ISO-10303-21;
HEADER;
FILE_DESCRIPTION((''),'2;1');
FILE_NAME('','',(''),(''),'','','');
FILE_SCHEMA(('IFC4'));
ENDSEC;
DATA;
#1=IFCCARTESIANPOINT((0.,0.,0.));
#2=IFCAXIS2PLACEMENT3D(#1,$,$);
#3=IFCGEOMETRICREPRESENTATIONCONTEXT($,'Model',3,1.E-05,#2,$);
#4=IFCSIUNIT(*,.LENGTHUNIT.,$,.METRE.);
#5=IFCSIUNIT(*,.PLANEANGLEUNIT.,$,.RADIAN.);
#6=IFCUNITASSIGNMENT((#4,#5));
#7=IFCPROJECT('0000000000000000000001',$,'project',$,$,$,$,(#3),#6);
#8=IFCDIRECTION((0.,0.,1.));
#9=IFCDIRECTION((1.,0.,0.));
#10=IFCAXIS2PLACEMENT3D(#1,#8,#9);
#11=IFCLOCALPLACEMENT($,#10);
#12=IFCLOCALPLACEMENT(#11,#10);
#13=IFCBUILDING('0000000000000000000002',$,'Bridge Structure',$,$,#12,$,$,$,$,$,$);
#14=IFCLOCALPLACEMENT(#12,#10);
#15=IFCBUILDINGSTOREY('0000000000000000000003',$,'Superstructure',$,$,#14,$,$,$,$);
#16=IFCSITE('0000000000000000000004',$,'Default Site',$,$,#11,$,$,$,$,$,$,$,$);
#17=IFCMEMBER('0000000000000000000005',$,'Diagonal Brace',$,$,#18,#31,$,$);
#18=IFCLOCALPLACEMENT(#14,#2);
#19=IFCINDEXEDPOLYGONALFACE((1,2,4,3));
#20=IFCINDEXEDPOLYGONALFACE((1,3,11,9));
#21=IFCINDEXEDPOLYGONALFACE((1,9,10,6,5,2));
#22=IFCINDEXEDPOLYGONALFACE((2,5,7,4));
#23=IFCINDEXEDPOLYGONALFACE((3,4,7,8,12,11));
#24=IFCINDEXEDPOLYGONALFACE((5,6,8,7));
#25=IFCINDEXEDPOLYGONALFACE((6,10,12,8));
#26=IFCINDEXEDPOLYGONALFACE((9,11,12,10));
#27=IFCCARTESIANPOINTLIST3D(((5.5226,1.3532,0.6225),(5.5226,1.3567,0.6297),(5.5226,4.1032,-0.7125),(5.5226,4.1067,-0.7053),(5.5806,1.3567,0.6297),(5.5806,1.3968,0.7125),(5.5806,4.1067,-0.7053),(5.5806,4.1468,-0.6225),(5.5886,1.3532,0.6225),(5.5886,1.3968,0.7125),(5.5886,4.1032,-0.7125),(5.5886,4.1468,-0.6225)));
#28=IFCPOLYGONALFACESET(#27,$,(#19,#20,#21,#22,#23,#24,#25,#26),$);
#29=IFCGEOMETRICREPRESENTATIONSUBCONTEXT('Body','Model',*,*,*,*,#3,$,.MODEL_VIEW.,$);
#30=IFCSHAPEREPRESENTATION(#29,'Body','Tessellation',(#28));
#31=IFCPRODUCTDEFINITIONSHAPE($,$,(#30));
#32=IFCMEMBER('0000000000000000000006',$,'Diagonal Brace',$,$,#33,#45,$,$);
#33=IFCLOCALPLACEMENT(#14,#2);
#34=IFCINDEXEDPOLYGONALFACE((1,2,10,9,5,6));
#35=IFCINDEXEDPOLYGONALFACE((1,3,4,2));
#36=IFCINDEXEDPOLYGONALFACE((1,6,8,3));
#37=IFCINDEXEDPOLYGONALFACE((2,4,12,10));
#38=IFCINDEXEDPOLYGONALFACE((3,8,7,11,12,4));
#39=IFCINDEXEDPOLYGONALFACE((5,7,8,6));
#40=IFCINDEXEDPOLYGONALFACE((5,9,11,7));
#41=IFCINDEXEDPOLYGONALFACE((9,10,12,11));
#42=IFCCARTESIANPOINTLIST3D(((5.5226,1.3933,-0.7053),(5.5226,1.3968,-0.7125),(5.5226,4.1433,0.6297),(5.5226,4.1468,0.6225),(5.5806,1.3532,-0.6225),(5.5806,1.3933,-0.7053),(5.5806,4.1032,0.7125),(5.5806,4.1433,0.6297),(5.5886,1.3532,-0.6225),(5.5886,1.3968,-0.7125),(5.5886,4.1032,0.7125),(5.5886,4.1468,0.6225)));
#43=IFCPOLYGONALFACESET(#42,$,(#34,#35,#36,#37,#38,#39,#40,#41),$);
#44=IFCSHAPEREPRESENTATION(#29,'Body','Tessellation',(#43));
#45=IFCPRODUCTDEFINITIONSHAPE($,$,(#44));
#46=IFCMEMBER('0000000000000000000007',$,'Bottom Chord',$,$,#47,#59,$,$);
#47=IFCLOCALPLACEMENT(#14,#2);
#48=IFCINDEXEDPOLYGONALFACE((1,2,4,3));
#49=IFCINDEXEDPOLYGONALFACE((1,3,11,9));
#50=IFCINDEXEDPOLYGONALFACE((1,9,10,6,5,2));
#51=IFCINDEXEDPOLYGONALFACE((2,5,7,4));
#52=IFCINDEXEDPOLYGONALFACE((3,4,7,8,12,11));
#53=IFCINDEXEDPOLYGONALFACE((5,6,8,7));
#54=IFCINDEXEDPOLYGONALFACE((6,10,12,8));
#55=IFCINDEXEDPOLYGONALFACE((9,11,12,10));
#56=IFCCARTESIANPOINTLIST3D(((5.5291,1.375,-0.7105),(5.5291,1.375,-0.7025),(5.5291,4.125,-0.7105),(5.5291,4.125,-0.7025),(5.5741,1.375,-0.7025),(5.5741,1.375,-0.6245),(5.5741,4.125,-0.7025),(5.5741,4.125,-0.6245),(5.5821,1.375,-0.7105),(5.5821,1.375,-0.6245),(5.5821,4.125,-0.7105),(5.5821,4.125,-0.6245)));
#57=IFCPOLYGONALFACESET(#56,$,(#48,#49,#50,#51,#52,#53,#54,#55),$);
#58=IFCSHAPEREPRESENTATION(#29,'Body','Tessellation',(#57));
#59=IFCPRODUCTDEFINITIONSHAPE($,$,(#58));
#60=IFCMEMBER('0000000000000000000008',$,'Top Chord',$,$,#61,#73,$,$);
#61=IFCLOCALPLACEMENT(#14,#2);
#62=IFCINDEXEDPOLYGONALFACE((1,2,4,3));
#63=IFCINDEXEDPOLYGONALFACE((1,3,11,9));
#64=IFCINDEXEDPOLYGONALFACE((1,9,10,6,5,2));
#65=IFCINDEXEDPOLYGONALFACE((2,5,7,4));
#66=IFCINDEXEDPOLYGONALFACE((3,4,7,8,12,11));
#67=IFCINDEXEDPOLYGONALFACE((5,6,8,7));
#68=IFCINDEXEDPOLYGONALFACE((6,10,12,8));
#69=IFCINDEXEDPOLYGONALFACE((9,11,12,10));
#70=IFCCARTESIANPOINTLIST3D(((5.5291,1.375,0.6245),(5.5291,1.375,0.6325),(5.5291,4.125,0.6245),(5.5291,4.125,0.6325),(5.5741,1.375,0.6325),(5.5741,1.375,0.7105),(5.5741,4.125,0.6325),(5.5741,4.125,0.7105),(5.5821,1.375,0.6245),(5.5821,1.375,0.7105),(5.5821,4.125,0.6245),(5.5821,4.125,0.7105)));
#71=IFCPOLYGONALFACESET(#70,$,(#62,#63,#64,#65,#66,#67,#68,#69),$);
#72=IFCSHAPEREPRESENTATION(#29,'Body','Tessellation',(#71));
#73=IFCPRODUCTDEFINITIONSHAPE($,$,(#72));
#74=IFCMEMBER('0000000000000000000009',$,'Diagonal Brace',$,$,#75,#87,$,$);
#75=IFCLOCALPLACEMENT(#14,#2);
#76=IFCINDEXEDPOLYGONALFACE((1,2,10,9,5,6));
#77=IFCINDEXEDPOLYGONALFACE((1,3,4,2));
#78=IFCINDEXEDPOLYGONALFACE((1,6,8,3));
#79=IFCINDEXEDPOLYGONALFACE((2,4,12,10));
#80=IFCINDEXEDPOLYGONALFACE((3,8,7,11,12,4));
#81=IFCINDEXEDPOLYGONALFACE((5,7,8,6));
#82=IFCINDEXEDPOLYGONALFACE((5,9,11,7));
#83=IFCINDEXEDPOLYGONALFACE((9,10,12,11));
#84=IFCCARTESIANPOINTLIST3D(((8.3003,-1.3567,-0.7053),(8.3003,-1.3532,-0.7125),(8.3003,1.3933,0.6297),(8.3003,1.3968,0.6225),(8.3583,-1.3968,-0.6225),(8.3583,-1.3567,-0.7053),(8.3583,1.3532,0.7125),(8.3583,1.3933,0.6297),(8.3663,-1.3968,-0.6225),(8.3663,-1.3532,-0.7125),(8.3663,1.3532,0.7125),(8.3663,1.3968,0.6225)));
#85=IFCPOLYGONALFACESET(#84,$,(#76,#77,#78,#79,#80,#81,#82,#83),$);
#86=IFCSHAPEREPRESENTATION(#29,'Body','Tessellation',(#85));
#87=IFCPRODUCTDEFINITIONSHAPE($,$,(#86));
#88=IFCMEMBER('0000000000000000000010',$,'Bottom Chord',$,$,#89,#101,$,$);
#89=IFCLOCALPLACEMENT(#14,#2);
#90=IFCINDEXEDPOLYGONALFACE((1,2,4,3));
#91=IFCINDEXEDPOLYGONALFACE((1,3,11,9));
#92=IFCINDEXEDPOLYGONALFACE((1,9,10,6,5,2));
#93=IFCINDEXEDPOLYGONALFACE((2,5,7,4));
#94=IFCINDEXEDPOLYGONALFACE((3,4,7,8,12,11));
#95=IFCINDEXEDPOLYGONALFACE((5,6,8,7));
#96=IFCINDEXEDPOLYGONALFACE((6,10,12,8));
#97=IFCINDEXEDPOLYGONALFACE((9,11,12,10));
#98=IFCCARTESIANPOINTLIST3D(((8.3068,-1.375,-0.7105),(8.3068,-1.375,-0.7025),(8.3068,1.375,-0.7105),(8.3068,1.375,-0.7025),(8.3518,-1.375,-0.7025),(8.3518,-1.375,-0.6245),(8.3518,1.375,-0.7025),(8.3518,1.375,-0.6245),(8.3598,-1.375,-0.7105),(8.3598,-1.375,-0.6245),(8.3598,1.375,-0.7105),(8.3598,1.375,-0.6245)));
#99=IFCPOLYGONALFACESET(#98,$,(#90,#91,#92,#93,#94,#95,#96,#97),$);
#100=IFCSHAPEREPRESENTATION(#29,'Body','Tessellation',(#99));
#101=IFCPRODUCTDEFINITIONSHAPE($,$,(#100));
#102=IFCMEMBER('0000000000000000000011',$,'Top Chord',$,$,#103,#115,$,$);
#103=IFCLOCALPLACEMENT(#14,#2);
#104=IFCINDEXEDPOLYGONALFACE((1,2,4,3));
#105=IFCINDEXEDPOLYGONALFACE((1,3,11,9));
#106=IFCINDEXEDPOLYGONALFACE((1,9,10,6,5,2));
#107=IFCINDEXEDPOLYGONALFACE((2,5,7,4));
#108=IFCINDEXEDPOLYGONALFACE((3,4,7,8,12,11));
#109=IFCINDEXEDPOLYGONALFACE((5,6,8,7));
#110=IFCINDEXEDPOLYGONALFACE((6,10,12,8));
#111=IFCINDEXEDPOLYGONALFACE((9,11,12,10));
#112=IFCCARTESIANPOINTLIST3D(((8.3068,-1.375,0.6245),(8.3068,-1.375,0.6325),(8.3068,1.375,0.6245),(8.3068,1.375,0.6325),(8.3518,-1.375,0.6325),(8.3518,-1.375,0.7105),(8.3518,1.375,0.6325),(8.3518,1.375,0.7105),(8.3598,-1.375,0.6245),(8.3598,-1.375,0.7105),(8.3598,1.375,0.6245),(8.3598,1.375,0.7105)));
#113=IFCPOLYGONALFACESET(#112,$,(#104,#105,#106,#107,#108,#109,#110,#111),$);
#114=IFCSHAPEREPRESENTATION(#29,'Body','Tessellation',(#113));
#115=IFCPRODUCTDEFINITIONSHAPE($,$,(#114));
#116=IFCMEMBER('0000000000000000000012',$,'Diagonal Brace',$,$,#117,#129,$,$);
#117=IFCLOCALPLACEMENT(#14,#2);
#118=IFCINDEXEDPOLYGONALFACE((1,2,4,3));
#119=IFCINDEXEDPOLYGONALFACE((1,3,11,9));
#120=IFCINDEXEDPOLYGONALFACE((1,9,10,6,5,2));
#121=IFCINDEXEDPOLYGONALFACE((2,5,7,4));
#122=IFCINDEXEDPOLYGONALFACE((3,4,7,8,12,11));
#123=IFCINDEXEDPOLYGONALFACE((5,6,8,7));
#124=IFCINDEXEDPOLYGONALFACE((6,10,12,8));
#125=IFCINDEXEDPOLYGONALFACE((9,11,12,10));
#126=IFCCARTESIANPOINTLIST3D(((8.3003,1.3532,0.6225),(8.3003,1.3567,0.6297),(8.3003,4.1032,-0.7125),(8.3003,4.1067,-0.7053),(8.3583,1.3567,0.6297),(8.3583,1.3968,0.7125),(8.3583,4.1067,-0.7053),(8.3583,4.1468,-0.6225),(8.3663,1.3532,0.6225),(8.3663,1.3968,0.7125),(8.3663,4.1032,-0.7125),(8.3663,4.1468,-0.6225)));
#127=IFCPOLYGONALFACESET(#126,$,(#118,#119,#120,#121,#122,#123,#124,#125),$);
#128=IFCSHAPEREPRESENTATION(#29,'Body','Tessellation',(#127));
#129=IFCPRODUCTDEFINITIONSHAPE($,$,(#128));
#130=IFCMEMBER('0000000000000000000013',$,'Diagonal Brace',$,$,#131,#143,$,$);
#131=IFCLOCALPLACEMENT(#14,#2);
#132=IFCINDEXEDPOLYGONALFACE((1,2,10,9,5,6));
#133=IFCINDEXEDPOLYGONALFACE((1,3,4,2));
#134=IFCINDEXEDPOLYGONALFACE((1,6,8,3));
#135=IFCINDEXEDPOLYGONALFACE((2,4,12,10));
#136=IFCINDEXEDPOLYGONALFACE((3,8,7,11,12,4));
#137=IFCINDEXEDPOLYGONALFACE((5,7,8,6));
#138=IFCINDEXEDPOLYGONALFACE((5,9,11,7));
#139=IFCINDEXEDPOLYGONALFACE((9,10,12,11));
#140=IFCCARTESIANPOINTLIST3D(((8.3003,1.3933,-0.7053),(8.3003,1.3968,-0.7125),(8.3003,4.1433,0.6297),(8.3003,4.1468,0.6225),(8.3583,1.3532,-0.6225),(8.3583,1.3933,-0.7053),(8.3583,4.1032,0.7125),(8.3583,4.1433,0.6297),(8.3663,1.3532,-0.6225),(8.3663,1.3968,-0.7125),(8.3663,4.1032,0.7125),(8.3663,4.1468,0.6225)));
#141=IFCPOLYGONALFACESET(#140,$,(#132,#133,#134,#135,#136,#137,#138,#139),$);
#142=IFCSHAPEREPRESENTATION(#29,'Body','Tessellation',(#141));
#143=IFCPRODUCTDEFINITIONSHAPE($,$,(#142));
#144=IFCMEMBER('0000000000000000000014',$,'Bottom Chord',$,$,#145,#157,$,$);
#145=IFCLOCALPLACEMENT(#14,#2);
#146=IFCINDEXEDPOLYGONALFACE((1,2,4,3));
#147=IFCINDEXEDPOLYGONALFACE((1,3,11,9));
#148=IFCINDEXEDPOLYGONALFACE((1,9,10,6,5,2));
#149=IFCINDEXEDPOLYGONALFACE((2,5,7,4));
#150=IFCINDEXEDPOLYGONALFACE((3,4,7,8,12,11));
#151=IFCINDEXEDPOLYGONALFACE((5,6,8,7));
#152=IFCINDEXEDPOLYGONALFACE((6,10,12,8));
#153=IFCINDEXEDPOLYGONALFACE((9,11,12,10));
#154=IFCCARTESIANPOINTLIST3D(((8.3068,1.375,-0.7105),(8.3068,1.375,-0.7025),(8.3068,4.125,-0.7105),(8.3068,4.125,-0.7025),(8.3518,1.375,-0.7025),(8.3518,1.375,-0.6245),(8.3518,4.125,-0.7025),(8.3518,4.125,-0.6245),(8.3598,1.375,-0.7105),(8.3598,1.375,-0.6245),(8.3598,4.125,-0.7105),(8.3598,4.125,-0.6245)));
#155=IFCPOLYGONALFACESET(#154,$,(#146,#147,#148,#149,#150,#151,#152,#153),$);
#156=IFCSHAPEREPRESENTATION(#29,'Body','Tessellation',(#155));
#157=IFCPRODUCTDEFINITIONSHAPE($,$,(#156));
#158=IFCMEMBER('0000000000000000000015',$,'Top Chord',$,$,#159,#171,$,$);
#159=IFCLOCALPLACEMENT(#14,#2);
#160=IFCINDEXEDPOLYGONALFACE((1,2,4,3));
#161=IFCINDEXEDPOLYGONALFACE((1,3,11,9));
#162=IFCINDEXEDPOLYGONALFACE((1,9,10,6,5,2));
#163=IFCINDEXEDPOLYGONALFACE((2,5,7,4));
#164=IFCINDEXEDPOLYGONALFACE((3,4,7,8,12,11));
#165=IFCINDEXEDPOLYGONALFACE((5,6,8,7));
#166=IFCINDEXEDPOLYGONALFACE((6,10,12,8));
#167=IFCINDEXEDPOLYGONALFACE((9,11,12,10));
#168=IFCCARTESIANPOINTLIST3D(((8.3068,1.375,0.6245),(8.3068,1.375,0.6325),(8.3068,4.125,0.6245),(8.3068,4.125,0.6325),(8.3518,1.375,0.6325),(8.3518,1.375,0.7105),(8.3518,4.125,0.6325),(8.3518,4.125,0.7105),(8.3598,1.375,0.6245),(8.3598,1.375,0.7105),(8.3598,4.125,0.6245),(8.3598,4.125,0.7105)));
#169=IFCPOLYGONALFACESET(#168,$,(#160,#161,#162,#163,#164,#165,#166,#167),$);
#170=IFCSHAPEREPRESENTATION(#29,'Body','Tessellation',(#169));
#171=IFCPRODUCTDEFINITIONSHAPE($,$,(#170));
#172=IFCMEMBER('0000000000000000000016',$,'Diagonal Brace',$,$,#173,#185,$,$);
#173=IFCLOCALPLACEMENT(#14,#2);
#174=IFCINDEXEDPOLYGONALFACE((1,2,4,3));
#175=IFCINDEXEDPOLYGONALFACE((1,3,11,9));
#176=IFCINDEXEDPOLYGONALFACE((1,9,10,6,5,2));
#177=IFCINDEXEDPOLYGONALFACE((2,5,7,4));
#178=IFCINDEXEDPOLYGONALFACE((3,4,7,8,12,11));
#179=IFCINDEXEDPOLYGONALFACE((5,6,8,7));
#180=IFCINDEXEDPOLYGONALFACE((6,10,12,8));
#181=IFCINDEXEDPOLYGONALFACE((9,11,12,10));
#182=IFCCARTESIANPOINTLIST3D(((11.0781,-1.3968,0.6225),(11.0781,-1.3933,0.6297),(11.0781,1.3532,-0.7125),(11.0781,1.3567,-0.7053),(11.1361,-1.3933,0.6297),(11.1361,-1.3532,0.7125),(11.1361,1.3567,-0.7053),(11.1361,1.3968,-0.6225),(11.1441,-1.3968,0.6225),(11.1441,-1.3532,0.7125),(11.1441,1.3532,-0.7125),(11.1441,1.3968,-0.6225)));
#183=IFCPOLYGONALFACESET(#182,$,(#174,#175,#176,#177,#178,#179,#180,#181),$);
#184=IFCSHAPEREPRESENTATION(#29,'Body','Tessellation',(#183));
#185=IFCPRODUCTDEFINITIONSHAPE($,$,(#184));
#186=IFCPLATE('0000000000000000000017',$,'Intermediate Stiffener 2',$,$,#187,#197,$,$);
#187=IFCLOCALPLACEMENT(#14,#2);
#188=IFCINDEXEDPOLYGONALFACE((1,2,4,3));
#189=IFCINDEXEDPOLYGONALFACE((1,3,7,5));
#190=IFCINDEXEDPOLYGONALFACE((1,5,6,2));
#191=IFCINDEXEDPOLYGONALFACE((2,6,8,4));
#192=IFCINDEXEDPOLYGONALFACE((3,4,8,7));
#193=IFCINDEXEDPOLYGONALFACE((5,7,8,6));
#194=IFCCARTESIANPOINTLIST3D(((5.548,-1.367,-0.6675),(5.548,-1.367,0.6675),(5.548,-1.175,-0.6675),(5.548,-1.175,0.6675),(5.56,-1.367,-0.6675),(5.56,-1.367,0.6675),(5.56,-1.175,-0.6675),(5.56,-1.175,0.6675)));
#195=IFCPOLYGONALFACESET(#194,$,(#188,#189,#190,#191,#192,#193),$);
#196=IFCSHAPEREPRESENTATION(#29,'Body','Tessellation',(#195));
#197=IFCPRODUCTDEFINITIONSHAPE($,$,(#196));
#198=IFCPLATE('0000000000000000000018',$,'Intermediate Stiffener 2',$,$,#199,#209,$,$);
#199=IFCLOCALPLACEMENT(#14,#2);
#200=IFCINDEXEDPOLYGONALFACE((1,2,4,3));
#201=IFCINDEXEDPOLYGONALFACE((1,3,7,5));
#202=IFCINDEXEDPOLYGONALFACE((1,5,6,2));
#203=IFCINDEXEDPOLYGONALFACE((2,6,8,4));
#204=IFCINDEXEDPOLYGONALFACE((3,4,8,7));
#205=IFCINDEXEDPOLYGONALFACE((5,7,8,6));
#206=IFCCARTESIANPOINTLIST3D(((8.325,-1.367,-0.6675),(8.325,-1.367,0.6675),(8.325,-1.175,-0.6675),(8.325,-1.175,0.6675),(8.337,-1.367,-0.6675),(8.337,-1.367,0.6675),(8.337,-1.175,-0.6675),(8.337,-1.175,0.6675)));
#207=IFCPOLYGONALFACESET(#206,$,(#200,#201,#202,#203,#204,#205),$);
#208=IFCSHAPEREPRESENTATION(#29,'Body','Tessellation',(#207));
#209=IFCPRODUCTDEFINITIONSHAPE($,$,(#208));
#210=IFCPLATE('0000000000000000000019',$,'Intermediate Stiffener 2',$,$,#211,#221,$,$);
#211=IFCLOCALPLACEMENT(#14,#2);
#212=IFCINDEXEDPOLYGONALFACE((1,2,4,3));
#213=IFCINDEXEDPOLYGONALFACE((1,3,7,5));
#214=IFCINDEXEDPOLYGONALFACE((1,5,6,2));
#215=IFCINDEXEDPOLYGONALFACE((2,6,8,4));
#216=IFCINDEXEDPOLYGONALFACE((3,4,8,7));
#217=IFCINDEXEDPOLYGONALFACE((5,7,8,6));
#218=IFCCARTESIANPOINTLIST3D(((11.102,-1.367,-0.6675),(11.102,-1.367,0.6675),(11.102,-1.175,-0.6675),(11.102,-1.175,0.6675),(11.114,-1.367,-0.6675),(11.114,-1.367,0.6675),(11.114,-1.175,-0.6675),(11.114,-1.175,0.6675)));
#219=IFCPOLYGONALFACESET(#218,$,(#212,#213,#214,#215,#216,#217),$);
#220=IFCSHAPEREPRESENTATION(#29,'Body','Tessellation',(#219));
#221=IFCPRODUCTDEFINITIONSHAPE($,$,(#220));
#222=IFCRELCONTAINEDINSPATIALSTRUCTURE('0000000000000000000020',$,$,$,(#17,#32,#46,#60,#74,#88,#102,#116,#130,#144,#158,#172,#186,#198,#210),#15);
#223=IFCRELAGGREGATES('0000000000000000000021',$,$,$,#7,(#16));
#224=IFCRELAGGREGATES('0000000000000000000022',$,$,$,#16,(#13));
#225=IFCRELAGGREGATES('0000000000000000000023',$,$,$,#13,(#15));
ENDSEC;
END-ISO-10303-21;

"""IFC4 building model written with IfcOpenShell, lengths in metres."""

from ifc_helpers import new_model, si_unit, frame, origin, origin_with_axes, origin_2d_with_axis, place, context, subcontext, project, spatial, rectangle, l_section, extrude, element, save


model = new_model("IFC4")

# Units and contexts
model_context = context("Model", 3, precision=1e-05, world=origin())
body_context = subcontext(model_context, "Body", "Model", "MODEL_VIEW")
ifc_project = project(units=[si_unit("LENGTHUNIT", "METRE"), si_unit("PLANEANGLEUNIT", "RADIAN")], contexts=[model_context])

# Site, building, storey
site_placement = place(None, origin_with_axes())
site = spatial("IfcSite", under=ifc_project, at=site_placement, Name="Default Site")
building_placement = place(site_placement, origin_with_axes())
building = spatial("IfcBuilding", under=site, at=building_placement, Name="Bridge Structure")
storey_placement = place(building_placement, origin_with_axes())
storey = spatial("IfcBuildingStorey", under=building, at=storey_placement, Name="Superstructure")

# Members
for number, where, z_axis, x_axis, name in (
    (1, (5.5556, 1.375, 0.6675), (0.0, 0.8996, -0.436715), (-1.0, 0.0, 0.0), "Diagonal Brace"),
    (2, (5.5556, 1.375, -0.6675), (0.0, 0.8996, 0.436715), (-1.0, 0.0, 0.0), "Diagonal Brace"),
):
    element("IfcMember", number, at=place(storey_placement, frame(where, z_axis=z_axis, x_axis=x_axis)), inside=storey, Name=name, context=body_context, shape_type="SweptSolid", body=[
        extrude(l_section(Depth=0.1, Width=0.066, Thickness=0.008, at=origin_2d_with_axis()), origin_with_axes(), (0.0, 0.0, 1.0), 3.0569),
    ])
for number, where, z_axis, x_axis, name in (
    (3, (5.5556, 1.375, -0.6675), (0.0, 1.0, 0.0), (-1.0, 0.0, 0.0), "Bottom Chord"),
    (4, (5.5556, 1.375, 0.6675), (0.0, 1.0, 0.0), (-1.0, 0.0, 0.0), "Top Chord"),
):
    element("IfcMember", number, at=place(storey_placement, frame(where, z_axis=z_axis, x_axis=x_axis)), inside=storey, Name=name, context=body_context, shape_type="SweptSolid", body=[
        extrude(l_section(Depth=0.086, Width=0.053, Thickness=0.008, at=origin_2d_with_axis()), origin_with_axes(), (0.0, 0.0, 1.0), 2.75),
    ])
member_1_placement = place(storey_placement, frame((8.3333, -1.375, -0.6675), z_axis=(0.0, 0.8996, 0.436715), x_axis=(-1.0, 0.0, 0.0)))
element("IfcMember", 5, at=member_1_placement, inside=storey, Name="Diagonal Brace", context=body_context, shape_type="SweptSolid", body=[
    extrude(l_section(Depth=0.1, Width=0.066, Thickness=0.008, at=origin_2d_with_axis()), origin_with_axes(), (0.0, 0.0, 1.0), 3.0569),
])
for number, where, z_axis, x_axis, name in (
    (6, (8.3333, -1.375, -0.6675), (0.0, 1.0, 0.0), (-1.0, 0.0, 0.0), "Bottom Chord"),
    (7, (8.3333, -1.375, 0.6675), (0.0, 1.0, 0.0), (-1.0, 0.0, 0.0), "Top Chord"),
):
    element("IfcMember", number, at=place(storey_placement, frame(where, z_axis=z_axis, x_axis=x_axis)), inside=storey, Name=name, context=body_context, shape_type="SweptSolid", body=[
        extrude(l_section(Depth=0.086, Width=0.053, Thickness=0.008, at=origin_2d_with_axis()), origin_with_axes(), (0.0, 0.0, 1.0), 2.75),
    ])
for number, where, z_axis, x_axis, name in (
    (8, (8.3333, 1.375, 0.6675), (0.0, 0.8996, -0.436715), (-1.0, 0.0, 0.0), "Diagonal Brace"),
    (9, (8.3333, 1.375, -0.6675), (0.0, 0.8996, 0.436715), (-1.0, 0.0, 0.0), "Diagonal Brace"),
):
    element("IfcMember", number, at=place(storey_placement, frame(where, z_axis=z_axis, x_axis=x_axis)), inside=storey, Name=name, context=body_context, shape_type="SweptSolid", body=[
        extrude(l_section(Depth=0.1, Width=0.066, Thickness=0.008, at=origin_2d_with_axis()), origin_with_axes(), (0.0, 0.0, 1.0), 3.0569),
    ])
for number, where, z_axis, x_axis, name in (
    (10, (8.3333, 1.375, -0.6675), (0.0, 1.0, 0.0), (-1.0, 0.0, 0.0), "Bottom Chord"),
    (11, (8.3333, 1.375, 0.6675), (0.0, 1.0, 0.0), (-1.0, 0.0, 0.0), "Top Chord"),
):
    element("IfcMember", number, at=place(storey_placement, frame(where, z_axis=z_axis, x_axis=x_axis)), inside=storey, Name=name, context=body_context, shape_type="SweptSolid", body=[
        extrude(l_section(Depth=0.086, Width=0.053, Thickness=0.008, at=origin_2d_with_axis()), origin_with_axes(), (0.0, 0.0, 1.0), 2.75),
    ])
member_2_placement = place(storey_placement, frame((11.1111, -1.375, 0.6675), z_axis=(0.0, 0.8996, -0.436715), x_axis=(-1.0, 0.0, 0.0)))
element("IfcMember", 12, at=member_2_placement, inside=storey, Name="Diagonal Brace", context=body_context, shape_type="SweptSolid", body=[
    extrude(l_section(Depth=0.1, Width=0.066, Thickness=0.008, at=origin_2d_with_axis()), origin_with_axes(), (0.0, 0.0, 1.0), 3.0569),
])

# Plates
for number, where, z_axis, x_axis, name in (
    (13, (5.554, -1.271, -0.6675), (0.0, 0.0, 1.0), (1.0, 0.0, 0.0), "Intermediate Stiffener 2"),
    (14, (8.331, -1.271, -0.6675), (0.0, 0.0, 1.0), (1.0, 0.0, 0.0), "Intermediate Stiffener 2"),
    (15, (11.108, -1.271, -0.6675), (0.0, 0.0, 1.0), (1.0, 0.0, 0.0), "Intermediate Stiffener 2"),
):
    element("IfcPlate", number, at=place(storey_placement, frame(where, z_axis=z_axis, x_axis=x_axis)), inside=storey, Name=name, context=body_context, shape_type="SweptSolid", body=[
        extrude(rectangle(XDim=0.012, YDim=0.192, at=origin_2d_with_axis()), origin_with_axes(), (0.0, 0.0, 1.0), 1.335),
    ])

save(model, "model.ifc")
